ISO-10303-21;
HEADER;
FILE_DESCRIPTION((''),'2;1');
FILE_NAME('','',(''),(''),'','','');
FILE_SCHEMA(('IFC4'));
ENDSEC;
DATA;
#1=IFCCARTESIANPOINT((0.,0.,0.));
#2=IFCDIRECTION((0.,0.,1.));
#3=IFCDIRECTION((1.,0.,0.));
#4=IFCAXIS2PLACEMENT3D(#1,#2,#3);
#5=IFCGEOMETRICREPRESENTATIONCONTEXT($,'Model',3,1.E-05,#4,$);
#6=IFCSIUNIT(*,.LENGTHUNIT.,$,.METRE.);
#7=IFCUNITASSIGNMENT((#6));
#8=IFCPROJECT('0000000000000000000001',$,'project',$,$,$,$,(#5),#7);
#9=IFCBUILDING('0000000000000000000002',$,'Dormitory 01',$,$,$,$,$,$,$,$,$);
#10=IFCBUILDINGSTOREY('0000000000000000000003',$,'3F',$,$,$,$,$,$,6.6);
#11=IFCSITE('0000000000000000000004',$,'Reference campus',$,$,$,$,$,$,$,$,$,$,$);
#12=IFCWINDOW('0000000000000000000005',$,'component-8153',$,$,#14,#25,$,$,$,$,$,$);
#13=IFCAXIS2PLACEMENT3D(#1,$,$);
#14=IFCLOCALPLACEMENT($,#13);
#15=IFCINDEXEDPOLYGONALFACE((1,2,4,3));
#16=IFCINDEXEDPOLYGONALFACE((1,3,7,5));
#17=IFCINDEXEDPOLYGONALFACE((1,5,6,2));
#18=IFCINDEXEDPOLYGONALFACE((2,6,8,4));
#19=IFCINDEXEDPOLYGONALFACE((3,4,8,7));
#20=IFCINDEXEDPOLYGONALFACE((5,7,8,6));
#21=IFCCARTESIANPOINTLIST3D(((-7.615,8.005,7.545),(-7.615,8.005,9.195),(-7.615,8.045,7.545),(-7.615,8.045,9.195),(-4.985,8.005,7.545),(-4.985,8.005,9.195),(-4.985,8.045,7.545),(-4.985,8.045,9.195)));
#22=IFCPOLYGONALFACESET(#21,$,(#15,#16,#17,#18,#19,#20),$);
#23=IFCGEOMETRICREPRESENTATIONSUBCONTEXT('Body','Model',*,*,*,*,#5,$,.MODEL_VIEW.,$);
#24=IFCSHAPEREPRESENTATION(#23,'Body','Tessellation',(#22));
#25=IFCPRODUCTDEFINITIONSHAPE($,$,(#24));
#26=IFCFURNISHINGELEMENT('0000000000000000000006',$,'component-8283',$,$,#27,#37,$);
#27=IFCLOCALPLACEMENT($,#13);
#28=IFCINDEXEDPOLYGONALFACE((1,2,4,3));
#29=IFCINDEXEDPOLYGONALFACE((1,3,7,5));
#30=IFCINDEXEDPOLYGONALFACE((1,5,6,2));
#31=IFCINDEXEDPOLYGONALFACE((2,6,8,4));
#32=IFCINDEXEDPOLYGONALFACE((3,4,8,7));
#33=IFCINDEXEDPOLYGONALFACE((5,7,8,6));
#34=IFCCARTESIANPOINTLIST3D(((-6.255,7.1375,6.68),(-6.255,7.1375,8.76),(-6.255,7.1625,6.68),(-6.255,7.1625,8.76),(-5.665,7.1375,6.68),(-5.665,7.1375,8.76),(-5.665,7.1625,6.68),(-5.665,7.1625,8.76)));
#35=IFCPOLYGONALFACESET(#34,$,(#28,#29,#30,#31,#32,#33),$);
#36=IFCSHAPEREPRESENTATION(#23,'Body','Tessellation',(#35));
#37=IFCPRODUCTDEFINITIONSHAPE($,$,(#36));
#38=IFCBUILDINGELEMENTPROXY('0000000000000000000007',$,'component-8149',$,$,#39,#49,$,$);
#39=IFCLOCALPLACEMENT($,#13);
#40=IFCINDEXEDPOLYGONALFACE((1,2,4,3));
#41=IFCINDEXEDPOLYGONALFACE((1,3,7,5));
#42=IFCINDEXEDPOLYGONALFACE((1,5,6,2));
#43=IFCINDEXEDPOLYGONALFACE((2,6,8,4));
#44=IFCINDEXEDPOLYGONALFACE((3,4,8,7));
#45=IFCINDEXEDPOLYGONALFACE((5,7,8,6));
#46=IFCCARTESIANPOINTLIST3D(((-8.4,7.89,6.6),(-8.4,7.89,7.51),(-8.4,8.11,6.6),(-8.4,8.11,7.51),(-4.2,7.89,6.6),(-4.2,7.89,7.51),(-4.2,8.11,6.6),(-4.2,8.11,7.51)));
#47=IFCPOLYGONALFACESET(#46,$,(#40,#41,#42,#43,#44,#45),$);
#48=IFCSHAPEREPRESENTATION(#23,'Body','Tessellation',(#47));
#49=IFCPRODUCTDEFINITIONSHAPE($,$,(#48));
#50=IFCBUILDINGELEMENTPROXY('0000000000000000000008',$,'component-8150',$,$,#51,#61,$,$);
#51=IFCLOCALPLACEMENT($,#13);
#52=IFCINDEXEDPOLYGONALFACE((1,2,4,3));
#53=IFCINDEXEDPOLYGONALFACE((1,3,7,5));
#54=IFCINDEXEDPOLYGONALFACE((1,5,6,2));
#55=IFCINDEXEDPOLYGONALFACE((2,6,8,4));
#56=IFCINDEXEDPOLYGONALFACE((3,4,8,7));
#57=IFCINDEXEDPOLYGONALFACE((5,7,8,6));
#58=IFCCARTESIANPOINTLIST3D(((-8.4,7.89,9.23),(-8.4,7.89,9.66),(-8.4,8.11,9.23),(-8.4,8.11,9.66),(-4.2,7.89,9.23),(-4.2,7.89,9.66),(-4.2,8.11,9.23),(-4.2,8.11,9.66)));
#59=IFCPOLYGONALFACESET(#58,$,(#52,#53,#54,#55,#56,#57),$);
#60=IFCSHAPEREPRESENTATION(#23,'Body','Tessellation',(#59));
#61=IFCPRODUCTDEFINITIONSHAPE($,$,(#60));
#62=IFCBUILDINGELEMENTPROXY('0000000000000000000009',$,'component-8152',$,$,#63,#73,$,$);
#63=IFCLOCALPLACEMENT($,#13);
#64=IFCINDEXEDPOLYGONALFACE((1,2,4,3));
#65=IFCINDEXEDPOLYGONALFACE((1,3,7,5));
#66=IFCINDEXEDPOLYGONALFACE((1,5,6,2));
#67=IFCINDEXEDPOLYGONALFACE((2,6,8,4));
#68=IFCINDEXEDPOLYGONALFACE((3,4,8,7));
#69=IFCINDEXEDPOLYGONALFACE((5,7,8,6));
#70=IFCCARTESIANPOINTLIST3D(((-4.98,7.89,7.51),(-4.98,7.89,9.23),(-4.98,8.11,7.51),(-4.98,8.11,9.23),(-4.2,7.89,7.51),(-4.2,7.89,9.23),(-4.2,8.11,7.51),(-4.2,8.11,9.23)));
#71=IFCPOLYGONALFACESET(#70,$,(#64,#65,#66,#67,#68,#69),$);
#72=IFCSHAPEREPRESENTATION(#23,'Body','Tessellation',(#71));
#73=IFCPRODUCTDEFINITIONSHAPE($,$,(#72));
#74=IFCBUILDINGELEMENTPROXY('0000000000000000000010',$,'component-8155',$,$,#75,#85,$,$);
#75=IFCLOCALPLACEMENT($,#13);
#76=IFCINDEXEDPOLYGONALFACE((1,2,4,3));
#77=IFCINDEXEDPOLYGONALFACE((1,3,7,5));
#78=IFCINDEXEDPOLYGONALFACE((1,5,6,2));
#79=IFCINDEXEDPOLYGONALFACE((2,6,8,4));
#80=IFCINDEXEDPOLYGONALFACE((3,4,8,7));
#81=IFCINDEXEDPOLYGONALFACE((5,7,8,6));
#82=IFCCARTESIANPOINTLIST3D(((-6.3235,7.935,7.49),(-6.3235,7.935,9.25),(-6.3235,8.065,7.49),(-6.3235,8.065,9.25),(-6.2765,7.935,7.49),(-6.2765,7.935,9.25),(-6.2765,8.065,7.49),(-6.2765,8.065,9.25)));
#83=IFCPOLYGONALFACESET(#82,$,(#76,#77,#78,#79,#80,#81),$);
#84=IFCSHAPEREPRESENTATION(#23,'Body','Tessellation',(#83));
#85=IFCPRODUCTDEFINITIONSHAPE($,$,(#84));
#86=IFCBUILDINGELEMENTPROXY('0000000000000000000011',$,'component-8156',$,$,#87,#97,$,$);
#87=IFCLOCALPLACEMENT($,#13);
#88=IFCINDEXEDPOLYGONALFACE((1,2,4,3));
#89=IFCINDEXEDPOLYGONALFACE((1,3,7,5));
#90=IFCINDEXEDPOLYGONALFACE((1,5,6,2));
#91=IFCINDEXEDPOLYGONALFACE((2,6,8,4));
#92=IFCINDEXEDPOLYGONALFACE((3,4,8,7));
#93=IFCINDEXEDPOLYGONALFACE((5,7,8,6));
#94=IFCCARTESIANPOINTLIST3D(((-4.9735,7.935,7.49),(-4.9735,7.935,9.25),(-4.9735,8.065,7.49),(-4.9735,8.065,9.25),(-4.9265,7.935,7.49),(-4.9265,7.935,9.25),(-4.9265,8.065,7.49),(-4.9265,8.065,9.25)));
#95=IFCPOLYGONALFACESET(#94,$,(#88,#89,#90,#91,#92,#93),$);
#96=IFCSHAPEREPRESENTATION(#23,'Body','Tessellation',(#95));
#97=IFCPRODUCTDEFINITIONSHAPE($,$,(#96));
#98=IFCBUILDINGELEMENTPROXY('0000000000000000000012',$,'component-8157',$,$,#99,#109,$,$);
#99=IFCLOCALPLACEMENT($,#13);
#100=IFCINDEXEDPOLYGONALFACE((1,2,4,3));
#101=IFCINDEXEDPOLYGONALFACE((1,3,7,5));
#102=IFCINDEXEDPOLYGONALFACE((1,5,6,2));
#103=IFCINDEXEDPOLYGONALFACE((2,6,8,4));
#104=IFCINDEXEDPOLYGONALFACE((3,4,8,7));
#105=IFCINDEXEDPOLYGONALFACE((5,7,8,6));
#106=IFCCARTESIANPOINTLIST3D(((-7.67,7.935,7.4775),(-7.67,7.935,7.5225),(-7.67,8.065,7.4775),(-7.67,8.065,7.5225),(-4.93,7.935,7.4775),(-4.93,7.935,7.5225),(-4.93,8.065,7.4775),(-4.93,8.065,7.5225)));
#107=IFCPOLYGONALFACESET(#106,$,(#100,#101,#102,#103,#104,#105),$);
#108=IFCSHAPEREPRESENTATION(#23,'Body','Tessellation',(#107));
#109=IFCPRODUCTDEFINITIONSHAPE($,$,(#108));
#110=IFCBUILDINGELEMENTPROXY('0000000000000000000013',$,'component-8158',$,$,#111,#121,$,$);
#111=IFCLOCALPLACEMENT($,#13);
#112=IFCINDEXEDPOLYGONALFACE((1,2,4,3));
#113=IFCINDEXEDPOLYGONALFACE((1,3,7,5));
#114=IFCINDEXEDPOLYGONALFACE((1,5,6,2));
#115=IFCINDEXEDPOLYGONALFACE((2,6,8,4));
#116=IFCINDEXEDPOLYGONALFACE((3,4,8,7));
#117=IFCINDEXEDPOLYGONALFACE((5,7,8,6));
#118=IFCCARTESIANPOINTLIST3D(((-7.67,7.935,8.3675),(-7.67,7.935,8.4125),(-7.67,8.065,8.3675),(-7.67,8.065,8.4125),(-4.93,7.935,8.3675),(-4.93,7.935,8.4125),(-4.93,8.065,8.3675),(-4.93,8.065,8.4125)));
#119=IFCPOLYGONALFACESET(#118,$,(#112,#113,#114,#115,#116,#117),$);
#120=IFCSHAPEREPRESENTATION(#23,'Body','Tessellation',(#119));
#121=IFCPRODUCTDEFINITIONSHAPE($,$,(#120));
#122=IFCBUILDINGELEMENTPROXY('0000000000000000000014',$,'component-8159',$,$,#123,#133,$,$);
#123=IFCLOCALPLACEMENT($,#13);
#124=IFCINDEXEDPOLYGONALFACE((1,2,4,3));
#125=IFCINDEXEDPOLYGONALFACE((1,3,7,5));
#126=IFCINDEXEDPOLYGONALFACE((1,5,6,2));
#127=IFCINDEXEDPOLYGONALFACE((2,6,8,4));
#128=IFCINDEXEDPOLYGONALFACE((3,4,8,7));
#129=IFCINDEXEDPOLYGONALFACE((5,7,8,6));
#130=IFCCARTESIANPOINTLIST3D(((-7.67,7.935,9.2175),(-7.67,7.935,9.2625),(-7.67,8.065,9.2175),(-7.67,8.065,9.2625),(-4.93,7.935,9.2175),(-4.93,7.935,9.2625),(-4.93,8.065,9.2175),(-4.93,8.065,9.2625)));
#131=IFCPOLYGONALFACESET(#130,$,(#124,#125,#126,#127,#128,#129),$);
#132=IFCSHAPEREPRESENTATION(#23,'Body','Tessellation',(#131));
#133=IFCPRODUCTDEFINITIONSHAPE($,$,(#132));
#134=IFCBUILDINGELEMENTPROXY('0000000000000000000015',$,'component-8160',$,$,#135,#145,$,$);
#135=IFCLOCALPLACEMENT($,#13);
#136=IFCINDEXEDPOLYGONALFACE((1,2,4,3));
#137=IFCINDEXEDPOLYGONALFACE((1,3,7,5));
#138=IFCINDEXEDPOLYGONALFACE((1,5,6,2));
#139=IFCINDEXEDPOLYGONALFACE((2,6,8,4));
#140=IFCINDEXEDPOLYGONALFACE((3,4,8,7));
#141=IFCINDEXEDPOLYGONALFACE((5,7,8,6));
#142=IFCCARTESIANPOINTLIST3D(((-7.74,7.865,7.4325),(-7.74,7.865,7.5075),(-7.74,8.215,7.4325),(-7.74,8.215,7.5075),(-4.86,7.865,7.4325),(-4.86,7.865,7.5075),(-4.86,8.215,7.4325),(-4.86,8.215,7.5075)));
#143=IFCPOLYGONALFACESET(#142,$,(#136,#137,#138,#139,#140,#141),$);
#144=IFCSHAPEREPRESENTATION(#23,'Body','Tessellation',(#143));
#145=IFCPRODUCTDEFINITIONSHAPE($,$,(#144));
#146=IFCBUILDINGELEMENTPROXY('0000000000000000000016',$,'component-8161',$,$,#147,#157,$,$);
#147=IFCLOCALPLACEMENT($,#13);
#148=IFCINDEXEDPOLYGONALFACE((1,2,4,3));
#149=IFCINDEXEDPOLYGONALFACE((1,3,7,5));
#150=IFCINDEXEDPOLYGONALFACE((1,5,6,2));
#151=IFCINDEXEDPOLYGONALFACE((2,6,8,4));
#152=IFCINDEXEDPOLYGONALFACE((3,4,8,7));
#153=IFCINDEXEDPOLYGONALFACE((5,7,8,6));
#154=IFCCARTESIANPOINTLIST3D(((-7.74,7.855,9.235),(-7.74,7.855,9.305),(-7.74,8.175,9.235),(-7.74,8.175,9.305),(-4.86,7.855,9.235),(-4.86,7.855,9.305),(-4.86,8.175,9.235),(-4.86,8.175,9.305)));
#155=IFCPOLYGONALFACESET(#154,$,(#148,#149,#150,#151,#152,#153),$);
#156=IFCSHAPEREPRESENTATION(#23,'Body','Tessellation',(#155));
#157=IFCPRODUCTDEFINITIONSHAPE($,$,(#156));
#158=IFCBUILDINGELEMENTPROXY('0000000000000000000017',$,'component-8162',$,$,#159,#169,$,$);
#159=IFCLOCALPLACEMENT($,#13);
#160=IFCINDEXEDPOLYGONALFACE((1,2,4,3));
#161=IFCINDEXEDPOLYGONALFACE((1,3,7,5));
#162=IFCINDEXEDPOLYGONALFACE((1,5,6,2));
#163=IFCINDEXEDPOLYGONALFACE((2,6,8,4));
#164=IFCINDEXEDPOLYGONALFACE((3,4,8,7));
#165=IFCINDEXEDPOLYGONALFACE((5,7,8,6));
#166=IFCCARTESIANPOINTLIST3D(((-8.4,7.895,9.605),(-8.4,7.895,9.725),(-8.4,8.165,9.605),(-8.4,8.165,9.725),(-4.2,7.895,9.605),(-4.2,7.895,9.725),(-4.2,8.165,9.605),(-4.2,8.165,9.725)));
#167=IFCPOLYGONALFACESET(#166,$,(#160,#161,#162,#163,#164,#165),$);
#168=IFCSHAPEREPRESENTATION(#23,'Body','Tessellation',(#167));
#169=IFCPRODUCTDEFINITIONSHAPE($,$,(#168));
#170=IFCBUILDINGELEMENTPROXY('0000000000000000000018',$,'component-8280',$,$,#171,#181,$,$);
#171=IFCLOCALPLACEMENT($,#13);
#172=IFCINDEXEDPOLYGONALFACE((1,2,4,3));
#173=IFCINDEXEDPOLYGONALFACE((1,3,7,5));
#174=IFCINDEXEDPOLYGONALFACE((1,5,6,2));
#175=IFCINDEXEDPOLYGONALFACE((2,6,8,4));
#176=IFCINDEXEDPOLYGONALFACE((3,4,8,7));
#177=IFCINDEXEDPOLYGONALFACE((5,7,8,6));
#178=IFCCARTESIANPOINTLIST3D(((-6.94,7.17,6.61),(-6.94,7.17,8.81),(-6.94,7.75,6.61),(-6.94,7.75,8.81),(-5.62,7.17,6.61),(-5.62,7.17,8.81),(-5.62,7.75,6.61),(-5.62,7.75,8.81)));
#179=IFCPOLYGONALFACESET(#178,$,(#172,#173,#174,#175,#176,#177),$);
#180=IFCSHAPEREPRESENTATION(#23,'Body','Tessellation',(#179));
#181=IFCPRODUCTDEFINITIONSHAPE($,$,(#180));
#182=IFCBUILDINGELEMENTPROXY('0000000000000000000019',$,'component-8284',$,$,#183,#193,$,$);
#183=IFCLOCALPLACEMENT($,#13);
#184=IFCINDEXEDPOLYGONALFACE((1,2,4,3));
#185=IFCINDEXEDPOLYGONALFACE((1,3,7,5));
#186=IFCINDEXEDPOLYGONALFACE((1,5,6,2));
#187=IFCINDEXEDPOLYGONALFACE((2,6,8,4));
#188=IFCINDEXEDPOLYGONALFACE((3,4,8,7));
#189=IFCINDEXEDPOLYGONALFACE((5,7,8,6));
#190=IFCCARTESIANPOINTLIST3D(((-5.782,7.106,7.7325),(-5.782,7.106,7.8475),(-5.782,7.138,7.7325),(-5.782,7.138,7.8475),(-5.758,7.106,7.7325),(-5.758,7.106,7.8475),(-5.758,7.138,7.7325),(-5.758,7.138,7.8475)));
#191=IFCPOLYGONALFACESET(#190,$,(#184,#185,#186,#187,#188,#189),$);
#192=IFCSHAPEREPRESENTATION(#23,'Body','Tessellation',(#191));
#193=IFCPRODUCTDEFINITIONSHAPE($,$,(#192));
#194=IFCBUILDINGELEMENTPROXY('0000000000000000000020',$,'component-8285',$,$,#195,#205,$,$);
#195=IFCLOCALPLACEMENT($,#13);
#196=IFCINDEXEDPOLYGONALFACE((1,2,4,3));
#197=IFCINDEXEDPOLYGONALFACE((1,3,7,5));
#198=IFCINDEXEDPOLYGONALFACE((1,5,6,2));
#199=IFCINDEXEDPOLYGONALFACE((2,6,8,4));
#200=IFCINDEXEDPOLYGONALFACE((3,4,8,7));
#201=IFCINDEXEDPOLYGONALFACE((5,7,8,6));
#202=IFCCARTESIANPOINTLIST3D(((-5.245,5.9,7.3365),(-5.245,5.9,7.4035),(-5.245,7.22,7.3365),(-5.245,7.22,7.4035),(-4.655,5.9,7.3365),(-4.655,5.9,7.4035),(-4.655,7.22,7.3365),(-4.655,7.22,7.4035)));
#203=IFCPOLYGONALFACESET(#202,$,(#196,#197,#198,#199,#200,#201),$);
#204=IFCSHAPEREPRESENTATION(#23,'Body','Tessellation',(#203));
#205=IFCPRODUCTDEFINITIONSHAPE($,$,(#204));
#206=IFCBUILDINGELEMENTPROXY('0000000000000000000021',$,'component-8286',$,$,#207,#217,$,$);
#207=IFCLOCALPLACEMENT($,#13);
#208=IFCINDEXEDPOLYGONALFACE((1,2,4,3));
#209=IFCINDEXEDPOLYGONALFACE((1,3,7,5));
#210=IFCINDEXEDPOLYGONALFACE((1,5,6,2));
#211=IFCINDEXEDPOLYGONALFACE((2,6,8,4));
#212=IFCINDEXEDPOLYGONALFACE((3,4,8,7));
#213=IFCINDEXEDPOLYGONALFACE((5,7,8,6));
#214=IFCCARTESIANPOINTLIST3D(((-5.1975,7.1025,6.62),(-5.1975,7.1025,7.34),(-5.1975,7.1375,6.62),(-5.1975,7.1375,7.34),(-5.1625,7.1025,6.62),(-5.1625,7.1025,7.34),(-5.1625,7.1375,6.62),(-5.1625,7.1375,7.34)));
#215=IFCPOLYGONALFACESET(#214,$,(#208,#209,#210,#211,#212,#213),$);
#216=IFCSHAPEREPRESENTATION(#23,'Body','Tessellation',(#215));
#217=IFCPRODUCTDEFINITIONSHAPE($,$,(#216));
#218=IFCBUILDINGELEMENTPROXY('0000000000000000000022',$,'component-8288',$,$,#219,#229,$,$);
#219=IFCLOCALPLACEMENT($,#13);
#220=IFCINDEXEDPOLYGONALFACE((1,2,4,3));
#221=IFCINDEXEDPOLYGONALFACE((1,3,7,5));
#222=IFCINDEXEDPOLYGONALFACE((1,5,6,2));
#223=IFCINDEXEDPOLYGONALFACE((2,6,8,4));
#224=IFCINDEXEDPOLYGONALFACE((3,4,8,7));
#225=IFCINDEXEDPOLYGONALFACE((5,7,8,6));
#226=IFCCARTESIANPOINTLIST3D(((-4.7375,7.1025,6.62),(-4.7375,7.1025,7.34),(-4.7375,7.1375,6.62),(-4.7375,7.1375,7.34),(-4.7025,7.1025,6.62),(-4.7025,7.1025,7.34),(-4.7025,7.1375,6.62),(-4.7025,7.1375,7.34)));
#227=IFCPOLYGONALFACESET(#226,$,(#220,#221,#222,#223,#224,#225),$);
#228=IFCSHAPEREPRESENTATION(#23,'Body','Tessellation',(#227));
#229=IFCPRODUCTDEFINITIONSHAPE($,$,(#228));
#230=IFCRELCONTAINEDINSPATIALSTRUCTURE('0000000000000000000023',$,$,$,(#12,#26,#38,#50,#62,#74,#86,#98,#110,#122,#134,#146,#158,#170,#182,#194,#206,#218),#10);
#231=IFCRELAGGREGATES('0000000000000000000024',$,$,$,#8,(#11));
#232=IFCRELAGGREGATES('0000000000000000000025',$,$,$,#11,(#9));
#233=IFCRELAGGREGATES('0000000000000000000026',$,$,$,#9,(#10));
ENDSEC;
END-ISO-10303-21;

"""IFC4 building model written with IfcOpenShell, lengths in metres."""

from ifc_helpers import new_model, si_unit, frame, origin, origin_with_axes, origin_2d, place, context, subcontext, project, spatial, rectangle, extrude, element, save


model = new_model("IFC4")

# Units and contexts
model_context = context("Model", 3, precision=1e-05, world=origin_with_axes())
body_context = subcontext(model_context, "Body", "Model", "MODEL_VIEW")
ifc_project = project(units=[si_unit("LENGTHUNIT", "METRE")], contexts=[model_context])

# Site, building, storey
site = spatial("IfcSite", under=ifc_project, Name="Reference campus")
building = spatial("IfcBuilding", under=site, Name="Dormitory 01")
storey = spatial("IfcBuildingStorey", under=building, Name="3F", Elevation=6.6)

# Window
window_placement = place(None, frame((-6.3, 8.025, 7.545), z_axis=(0.0, 0.0, 1.0), x_axis=(1.0, 0.0, 0.0)))
element("IfcWindow", 1, at=window_placement, inside=storey, Name="component-8153", context=body_context, shape_type="SweptSolid", body=[
    extrude(rectangle(XDim=2.63, YDim=0.04, at=origin_2d()), origin(), (0.0, 0.0, 1.0), 1.65),
])

# Furnishing element
furnishing_placement = place(None, frame((-5.96, 7.15, 6.68), z_axis=(0.0, 0.0, 1.0), x_axis=(1.0, 0.0, 0.0)))
element("IfcFurnishingElement", 2, at=furnishing_placement, inside=storey, Name="component-8283", context=body_context, shape_type="SweptSolid", body=[
    extrude(rectangle(XDim=0.59, YDim=0.025, at=origin_2d()), origin(), (0.0, 0.0, 1.0), 2.08),
])

# Building element proxies
proxy_1_placement = place(None, frame((-6.3, 8.0, 6.6), z_axis=(0.0, 0.0, 1.0), x_axis=(1.0, 0.0, 0.0)))
element("IfcBuildingElementProxy", 3, at=proxy_1_placement, inside=storey, Name="component-8149", context=body_context, shape_type="SweptSolid", body=[
    extrude(rectangle(XDim=4.2, YDim=0.22, at=origin_2d()), origin(), (0.0, 0.0, 1.0), 0.91),
])
proxy_2_placement = place(None, frame((-6.3, 8.0, 9.23), z_axis=(0.0, 0.0, 1.0), x_axis=(1.0, 0.0, 0.0)))
element("IfcBuildingElementProxy", 4, at=proxy_2_placement, inside=storey, Name="component-8150", context=body_context, shape_type="SweptSolid", body=[
    extrude(rectangle(XDim=4.2, YDim=0.22, at=origin_2d()), origin(), (0.0, 0.0, 1.0), 0.43),
])
proxy_3_placement = place(None, frame((-4.59, 8.0, 7.51), z_axis=(0.0, 0.0, 1.0), x_axis=(1.0, 0.0, 0.0)))
element("IfcBuildingElementProxy", 5, at=proxy_3_placement, inside=storey, Name="component-8152", context=body_context, shape_type="SweptSolid", body=[
    extrude(rectangle(XDim=0.78, YDim=0.22, at=origin_2d()), origin(), (0.0, 0.0, 1.0), 1.72),
])
for number, where, z_axis, x_axis, name in (
    (6, (-6.3, 8.0, 7.49), (0.0, 0.0, 1.0), (1.0, 0.0, 0.0), "component-8155"),
    (7, (-4.95, 8.0, 7.49), (0.0, 0.0, 1.0), (1.0, 0.0, 0.0), "component-8156"),
):
    element("IfcBuildingElementProxy", number, at=place(None, frame(where, z_axis=z_axis, x_axis=x_axis)), inside=storey, Name=name, context=body_context, shape_type="SweptSolid", body=[
        extrude(rectangle(XDim=0.047, YDim=0.13, at=origin_2d()), origin(), (0.0, 0.0, 1.0), 1.76),
    ])
for number, where, z_axis, x_axis, name in (
    (8, (-6.3, 8.0, 7.4775), (0.0, 0.0, 1.0), (1.0, 0.0, 0.0), "component-8157"),
    (9, (-6.3, 8.0, 8.3675), (0.0, 0.0, 1.0), (1.0, 0.0, 0.0), "component-8158"),
    (10, (-6.3, 8.0, 9.2175), (0.0, 0.0, 1.0), (1.0, 0.0, 0.0), "component-8159"),
):
    element("IfcBuildingElementProxy", number, at=place(None, frame(where, z_axis=z_axis, x_axis=x_axis)), inside=storey, Name=name, context=body_context, shape_type="SweptSolid", body=[
        extrude(rectangle(XDim=2.74, YDim=0.13, at=origin_2d()), origin(), (0.0, 0.0, 1.0), 0.045),
    ])
proxy_4_placement = place(None, frame((-6.3, 8.04, 7.4325), z_axis=(0.0, 0.0, 1.0), x_axis=(1.0, 0.0, 0.0)))
element("IfcBuildingElementProxy", 11, at=proxy_4_placement, inside=storey, Name="component-8160", context=body_context, shape_type="SweptSolid", body=[
    extrude(rectangle(XDim=2.88, YDim=0.35, at=origin_2d()), origin(), (0.0, 0.0, 1.0), 0.075),
])
proxy_5_placement = place(None, frame((-6.3, 8.015, 9.235), z_axis=(0.0, 0.0, 1.0), x_axis=(1.0, 0.0, 0.0)))
element("IfcBuildingElementProxy", 12, at=proxy_5_placement, inside=storey, Name="component-8161", context=body_context, shape_type="SweptSolid", body=[
    extrude(rectangle(XDim=2.88, YDim=0.32, at=origin_2d()), origin(), (0.0, 0.0, 1.0), 0.07),
])
proxy_6_placement = place(None, frame((-6.3, 8.03, 9.605), z_axis=(0.0, 0.0, 1.0), x_axis=(1.0, 0.0, 0.0)))
element("IfcBuildingElementProxy", 13, at=proxy_6_placement, inside=storey, Name="component-8162", context=body_context, shape_type="SweptSolid", body=[
    extrude(rectangle(XDim=4.2, YDim=0.27, at=origin_2d()), origin(), (0.0, 0.0, 1.0), 0.12),
])
proxy_7_placement = place(None, frame((-6.28, 7.46, 6.61), z_axis=(0.0, 0.0, 1.0), x_axis=(1.0, 0.0, 0.0)))
element("IfcBuildingElementProxy", 14, at=proxy_7_placement, inside=storey, Name="component-8280", context=body_context, shape_type="SweptSolid", body=[
    extrude(rectangle(XDim=1.32, YDim=0.58, at=origin_2d()), origin(), (0.0, 0.0, 1.0), 2.2),
])
proxy_8_placement = place(None, frame((-5.77, 7.122, 7.7325), z_axis=(0.0, 0.0, 1.0), x_axis=(1.0, 0.0, 0.0)))
element("IfcBuildingElementProxy", 15, at=proxy_8_placement, inside=storey, Name="component-8284", context=body_context, shape_type="SweptSolid", body=[
    extrude(rectangle(XDim=0.024, YDim=0.032, at=origin_2d()), origin(), (0.0, 0.0, 1.0), 0.115),
])
proxy_9_placement = place(None, frame((-4.95, 6.56, 7.3365), z_axis=(0.0, 0.0, 1.0), x_axis=(1.0, 0.0, 0.0)))
element("IfcBuildingElementProxy", 16, at=proxy_9_placement, inside=storey, Name="component-8285", context=body_context, shape_type="SweptSolid", body=[
    extrude(rectangle(XDim=0.59, YDim=1.32, at=origin_2d()), origin(), (0.0, 0.0, 1.0), 0.067),
])
for number, where, z_axis, x_axis, name in (
    (17, (-5.18, 7.12, 6.62), (0.0, 0.0, 1.0), (1.0, 0.0, 0.0), "component-8286"),
    (18, (-4.72, 7.12, 6.62), (0.0, 0.0, 1.0), (1.0, 0.0, 0.0), "component-8288"),
):
    element("IfcBuildingElementProxy", number, at=place(None, frame(where, z_axis=z_axis, x_axis=x_axis)), inside=storey, Name=name, context=body_context, shape_type="SweptSolid", body=[
        extrude(rectangle(XDim=0.035, YDim=0.035, at=origin_2d()), origin(), (0.0, 0.0, 1.0), 0.72),
    ])

save(model, "model.ifc")
